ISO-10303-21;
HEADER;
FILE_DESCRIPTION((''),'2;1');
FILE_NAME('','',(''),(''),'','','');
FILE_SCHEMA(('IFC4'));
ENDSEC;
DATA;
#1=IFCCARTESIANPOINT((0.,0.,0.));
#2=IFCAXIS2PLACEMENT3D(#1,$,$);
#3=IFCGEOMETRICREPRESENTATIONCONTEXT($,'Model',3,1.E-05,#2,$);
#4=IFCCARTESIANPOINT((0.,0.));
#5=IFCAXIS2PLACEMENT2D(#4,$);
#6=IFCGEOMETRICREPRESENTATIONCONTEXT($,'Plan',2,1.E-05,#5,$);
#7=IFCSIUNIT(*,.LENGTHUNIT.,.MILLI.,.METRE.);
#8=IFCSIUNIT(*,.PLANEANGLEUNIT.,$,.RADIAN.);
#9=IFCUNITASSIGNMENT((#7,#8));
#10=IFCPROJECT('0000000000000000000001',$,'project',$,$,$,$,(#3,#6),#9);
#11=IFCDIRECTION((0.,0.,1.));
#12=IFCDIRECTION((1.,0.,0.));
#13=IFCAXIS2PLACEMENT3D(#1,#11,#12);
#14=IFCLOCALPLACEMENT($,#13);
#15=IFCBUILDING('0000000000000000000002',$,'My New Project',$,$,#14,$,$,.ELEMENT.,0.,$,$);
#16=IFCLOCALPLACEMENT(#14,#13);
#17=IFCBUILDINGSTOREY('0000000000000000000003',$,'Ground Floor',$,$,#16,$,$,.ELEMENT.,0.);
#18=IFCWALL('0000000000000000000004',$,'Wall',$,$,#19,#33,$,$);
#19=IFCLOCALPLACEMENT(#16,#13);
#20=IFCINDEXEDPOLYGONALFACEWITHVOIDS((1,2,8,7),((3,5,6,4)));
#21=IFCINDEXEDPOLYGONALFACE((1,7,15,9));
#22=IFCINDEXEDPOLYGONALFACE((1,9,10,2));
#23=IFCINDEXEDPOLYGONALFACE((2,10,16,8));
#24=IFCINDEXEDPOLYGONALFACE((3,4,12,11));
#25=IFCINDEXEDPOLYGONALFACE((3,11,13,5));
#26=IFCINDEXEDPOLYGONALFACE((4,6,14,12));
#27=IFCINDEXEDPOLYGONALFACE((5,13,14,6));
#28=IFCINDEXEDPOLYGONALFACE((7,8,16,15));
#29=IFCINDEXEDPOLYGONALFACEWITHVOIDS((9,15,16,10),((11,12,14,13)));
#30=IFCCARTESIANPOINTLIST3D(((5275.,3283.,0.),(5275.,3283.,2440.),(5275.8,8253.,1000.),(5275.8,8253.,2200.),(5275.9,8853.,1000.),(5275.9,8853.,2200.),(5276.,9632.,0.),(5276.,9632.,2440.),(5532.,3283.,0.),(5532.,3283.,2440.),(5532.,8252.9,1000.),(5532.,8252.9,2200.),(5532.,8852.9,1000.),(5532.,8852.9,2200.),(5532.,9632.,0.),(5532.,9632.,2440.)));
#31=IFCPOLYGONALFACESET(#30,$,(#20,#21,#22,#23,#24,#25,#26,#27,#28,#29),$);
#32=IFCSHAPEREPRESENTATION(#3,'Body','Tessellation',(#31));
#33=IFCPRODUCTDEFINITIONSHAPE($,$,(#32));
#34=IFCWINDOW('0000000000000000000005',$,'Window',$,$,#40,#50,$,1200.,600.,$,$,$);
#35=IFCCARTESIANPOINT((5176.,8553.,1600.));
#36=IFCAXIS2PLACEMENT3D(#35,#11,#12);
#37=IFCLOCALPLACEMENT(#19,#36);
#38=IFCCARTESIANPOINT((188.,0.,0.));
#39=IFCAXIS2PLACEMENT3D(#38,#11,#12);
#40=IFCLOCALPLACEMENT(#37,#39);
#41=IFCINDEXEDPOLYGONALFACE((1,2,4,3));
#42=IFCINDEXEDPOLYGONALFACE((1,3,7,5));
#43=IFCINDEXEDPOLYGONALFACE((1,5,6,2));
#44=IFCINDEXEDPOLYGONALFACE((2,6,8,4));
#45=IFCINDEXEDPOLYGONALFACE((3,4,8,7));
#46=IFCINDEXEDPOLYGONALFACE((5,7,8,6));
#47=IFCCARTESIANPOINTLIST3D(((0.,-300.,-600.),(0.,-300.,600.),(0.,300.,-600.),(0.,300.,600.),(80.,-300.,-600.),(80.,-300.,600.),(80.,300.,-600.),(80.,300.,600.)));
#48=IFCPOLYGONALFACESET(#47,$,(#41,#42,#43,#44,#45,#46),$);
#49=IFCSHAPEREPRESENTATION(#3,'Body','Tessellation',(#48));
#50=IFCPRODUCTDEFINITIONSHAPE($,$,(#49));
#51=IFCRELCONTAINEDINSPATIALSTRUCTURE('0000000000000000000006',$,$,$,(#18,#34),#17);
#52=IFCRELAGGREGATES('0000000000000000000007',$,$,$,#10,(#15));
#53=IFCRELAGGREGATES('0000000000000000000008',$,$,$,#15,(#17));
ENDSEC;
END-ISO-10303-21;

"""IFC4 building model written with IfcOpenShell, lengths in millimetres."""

from ifc_helpers import new_model, si_unit, frame, origin, origin_with_axes, origin_2d, origin_2d_with_axis, place, context, project, spatial, polyline, rectangle, outline, extrude, element, fill, save


model = new_model("IFC4")

# Units and contexts
model_context = context("Model", 3, precision=1e-05, world=origin())
plan_context = context("Plan", 2, precision=1e-05, world=origin_2d())
ifc_project = project(units=[si_unit("LENGTHUNIT", "METRE", prefix="MILLI"), si_unit("PLANEANGLEUNIT", "RADIAN")], contexts=[model_context, plan_context])

# Building, storey
building_placement = place(None, origin_with_axes())
building = spatial("IfcBuilding", under=ifc_project, at=building_placement, Name="My New Project", CompositionType="ELEMENT", ElevationOfRefHeight=0.0)
storey_placement = place(building_placement, origin_with_axes())
storey = spatial("IfcBuildingStorey", under=building, at=storey_placement, Name="Ground Floor", CompositionType="ELEMENT", Elevation=0.0)

# Wall, opening, window
wall_1_placement = place(storey_placement, origin_with_axes())
wall_1 = element("IfcWall", 1, at=wall_1_placement, inside=storey, Name="Wall", context=model_context, shape_type="SweptSolid", body=[
    extrude(outline(polyline([(5404.0, 3283.0, 0.0), (5275.0, 3283.0, 0.0), (5276.0, 9632.0, 0.0), (5404.0, 9632.0, 0.0), (5532.0, 9632.0, 0.0), (5532.0, 3283.0, 0.0), (5404.0, 3283.0, 0.0)])), origin_with_axes(), (0.0, 0.0, 1.0), 2440.0),
])
opening_1_placement = place(wall_1_placement, frame((5176.0, 8553.0, 1600.0), z_axis=(0.0, 0.0, 1.0), x_axis=(1.0, 0.0, 0.0)))
opening_1 = element("IfcOpeningElement", 2, at=opening_1_placement, cuts=wall_1, PredefinedType="OPENING", context=model_context, shape_type="SweptSolid", body=[
    extrude(rectangle(XDim=600.0, YDim=1200.0, at=origin_2d_with_axis()), frame((0.0, 0.0, 0.0), z_axis=(6349.0, -0.981, 0.0), x_axis=(0.981, 6349.0, 0.0)), (0.0, 0.0, 1.0), 457.0),
])
window_1_placement = place(opening_1_placement, frame((188.0, 0.0, 0.0), z_axis=(0.0, 0.0, 1.0), x_axis=(1.0, 0.0, 0.0)))
window_1 = element("IfcWindow", 3, at=window_1_placement, inside=storey, Name="Window", OverallHeight=1200.0, OverallWidth=600.0, context=model_context, shape_type="SweptSolid", body=[
    extrude(outline(polyline([(300.0, 600.0, 0.0), (300.0, -600.0, 0.0), (-300.0, -600.0, 0.0), (-300.0, 600.0, 0.0), (300.0, 600.0, 0.0)])), frame((0.0, 0.0, 0.0), z_axis=(6349.0, -0.981, 0.0), x_axis=(0.981, 6349.0, 0.0)), (0.0, 0.0, 1.0), 80.0),
])
fill(opening_1, window_1)

save(model, "model.ifc")
